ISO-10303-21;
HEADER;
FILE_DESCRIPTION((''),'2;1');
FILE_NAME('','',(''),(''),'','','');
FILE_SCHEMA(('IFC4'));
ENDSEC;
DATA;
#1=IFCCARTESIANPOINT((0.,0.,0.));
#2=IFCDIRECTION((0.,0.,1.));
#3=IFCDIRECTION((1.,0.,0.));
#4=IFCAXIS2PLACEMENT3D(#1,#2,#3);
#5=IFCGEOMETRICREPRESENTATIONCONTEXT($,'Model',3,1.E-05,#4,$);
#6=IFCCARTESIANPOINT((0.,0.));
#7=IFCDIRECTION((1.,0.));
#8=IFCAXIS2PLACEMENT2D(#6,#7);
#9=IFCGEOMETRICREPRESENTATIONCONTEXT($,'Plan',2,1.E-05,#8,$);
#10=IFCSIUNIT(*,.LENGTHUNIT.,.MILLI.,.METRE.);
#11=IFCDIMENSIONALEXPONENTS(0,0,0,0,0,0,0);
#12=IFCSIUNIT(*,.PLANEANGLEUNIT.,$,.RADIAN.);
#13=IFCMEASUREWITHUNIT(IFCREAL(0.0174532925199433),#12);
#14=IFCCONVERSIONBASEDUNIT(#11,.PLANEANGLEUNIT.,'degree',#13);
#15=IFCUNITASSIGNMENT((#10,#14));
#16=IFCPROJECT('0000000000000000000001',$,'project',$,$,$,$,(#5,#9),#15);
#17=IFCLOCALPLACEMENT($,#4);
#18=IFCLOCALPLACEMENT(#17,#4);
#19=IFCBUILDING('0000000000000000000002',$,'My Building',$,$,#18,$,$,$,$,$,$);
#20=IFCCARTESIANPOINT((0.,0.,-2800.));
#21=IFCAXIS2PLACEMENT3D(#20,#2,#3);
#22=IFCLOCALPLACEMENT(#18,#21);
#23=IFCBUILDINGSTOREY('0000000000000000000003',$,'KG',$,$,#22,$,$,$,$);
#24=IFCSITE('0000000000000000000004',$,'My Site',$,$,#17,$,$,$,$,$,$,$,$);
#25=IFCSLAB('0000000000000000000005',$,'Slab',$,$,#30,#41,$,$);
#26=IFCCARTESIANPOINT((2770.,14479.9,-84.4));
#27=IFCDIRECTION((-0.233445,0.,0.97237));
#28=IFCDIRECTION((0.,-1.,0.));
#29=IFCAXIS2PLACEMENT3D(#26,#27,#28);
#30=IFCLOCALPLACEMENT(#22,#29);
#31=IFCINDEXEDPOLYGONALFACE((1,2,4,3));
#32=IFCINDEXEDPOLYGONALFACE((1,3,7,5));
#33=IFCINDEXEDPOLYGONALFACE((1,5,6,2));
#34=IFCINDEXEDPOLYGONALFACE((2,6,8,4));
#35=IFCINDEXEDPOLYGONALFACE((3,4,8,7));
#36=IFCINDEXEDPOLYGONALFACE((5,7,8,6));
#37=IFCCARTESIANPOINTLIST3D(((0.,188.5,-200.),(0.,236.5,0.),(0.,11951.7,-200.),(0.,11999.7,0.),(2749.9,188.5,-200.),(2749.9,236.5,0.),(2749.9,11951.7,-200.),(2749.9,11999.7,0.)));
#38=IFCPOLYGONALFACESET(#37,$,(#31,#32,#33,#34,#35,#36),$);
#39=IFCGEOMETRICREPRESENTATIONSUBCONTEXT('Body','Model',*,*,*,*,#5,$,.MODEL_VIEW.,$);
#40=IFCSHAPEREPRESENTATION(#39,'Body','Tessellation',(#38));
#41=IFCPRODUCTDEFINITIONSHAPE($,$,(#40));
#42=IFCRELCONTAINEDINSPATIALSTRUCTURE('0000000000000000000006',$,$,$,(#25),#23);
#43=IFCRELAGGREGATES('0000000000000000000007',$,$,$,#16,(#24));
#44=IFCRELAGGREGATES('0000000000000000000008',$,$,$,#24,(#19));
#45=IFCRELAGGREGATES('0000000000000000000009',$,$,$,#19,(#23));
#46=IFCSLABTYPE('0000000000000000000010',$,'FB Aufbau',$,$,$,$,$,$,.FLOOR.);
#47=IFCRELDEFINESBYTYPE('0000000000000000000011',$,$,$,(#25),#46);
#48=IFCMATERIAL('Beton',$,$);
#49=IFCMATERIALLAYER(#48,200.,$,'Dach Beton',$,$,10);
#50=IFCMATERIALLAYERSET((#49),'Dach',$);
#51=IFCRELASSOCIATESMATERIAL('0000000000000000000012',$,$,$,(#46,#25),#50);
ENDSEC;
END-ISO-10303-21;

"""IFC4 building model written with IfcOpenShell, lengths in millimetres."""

from ifc_helpers import new_model, entity, si_unit, converted_unit, frame, origin_with_axes, origin_2d_with_axis, place, context, subcontext, project, spatial, indexed_curve, outline, extrude, material, layer, layer_set, layer_usage, type_object, element, save


model = new_model("IFC4")

# Units and contexts
model_context = context("Model", 3, precision=1e-05, world=origin_with_axes())
plan_context = context("Plan", 2, precision=1e-05, world=origin_2d_with_axis())
body_context = subcontext(model_context, "Body", "Model", "MODEL_VIEW")
ifc_project = project(units=[si_unit("LENGTHUNIT", "METRE", prefix="MILLI"), converted_unit("PLANEANGLEUNIT", "degree", entity("IfcReal", 0.0174532925199433), si_unit("PLANEANGLEUNIT", "RADIAN"), dimensions=[0, 0, 0, 0, 0, 0, 0])], contexts=[model_context, plan_context])

# Site, building, storey
site_placement = place(None, origin_with_axes())
site = spatial("IfcSite", under=ifc_project, at=site_placement, Name="My Site")
building_placement = place(site_placement, origin_with_axes())
building = spatial("IfcBuilding", under=site, at=building_placement, Name="My Building")
storey_placement = place(building_placement, frame((0.0, 0.0, -2800.0), z_axis=(0.0, 0.0, 1.0), x_axis=(1.0, 0.0, 0.0)))
storey = spatial("IfcBuildingStorey", under=building, at=storey_placement, Name="KG")

# Slab
ifc_material_1 = material(Name="Beton")
ifc_layer_1 = layer(ifc_material_1, 200.0, Name="Dach Beton", Priority=10)
ifc_layer_set_1 = layer_set([ifc_layer_1], Name="Dach")
slab_type = type_object("IfcSlabType", Name="FB Aufbau", PredefinedType="FLOOR", material=ifc_layer_set_1)
ifc_layer_usage_1 = layer_usage(ifc_layer_set_1, "AXIS3", "POSITIVE", -200.0)
slab_1_placement = place(storey_placement, frame((2770.0, 14479.9, -84.4), z_axis=(-0.233445, 0.0, 0.97237), x_axis=(0.0, -1.0, 0.0)))
element("IfcSlab", 1, at=slab_1_placement, inside=storey, type_object=slab_type, material=ifc_layer_usage_1, Name="Slab", context=body_context, shape_type="SweptSolid", body=[
    extrude(outline(indexed_curve([(0.0, 236.5), (2749.9, 236.5), (2749.9, 11999.7), (0.0, 11999.7), (0.0, 236.5)])), frame((0.0, -48.0, -200.0), z_axis=(0.0, 0.0, 1.0), x_axis=(1.0, 0.0, 0.0)), (0.0, 0.233445, 0.97237), 205.7),
])

save(model, "model.ifc")
